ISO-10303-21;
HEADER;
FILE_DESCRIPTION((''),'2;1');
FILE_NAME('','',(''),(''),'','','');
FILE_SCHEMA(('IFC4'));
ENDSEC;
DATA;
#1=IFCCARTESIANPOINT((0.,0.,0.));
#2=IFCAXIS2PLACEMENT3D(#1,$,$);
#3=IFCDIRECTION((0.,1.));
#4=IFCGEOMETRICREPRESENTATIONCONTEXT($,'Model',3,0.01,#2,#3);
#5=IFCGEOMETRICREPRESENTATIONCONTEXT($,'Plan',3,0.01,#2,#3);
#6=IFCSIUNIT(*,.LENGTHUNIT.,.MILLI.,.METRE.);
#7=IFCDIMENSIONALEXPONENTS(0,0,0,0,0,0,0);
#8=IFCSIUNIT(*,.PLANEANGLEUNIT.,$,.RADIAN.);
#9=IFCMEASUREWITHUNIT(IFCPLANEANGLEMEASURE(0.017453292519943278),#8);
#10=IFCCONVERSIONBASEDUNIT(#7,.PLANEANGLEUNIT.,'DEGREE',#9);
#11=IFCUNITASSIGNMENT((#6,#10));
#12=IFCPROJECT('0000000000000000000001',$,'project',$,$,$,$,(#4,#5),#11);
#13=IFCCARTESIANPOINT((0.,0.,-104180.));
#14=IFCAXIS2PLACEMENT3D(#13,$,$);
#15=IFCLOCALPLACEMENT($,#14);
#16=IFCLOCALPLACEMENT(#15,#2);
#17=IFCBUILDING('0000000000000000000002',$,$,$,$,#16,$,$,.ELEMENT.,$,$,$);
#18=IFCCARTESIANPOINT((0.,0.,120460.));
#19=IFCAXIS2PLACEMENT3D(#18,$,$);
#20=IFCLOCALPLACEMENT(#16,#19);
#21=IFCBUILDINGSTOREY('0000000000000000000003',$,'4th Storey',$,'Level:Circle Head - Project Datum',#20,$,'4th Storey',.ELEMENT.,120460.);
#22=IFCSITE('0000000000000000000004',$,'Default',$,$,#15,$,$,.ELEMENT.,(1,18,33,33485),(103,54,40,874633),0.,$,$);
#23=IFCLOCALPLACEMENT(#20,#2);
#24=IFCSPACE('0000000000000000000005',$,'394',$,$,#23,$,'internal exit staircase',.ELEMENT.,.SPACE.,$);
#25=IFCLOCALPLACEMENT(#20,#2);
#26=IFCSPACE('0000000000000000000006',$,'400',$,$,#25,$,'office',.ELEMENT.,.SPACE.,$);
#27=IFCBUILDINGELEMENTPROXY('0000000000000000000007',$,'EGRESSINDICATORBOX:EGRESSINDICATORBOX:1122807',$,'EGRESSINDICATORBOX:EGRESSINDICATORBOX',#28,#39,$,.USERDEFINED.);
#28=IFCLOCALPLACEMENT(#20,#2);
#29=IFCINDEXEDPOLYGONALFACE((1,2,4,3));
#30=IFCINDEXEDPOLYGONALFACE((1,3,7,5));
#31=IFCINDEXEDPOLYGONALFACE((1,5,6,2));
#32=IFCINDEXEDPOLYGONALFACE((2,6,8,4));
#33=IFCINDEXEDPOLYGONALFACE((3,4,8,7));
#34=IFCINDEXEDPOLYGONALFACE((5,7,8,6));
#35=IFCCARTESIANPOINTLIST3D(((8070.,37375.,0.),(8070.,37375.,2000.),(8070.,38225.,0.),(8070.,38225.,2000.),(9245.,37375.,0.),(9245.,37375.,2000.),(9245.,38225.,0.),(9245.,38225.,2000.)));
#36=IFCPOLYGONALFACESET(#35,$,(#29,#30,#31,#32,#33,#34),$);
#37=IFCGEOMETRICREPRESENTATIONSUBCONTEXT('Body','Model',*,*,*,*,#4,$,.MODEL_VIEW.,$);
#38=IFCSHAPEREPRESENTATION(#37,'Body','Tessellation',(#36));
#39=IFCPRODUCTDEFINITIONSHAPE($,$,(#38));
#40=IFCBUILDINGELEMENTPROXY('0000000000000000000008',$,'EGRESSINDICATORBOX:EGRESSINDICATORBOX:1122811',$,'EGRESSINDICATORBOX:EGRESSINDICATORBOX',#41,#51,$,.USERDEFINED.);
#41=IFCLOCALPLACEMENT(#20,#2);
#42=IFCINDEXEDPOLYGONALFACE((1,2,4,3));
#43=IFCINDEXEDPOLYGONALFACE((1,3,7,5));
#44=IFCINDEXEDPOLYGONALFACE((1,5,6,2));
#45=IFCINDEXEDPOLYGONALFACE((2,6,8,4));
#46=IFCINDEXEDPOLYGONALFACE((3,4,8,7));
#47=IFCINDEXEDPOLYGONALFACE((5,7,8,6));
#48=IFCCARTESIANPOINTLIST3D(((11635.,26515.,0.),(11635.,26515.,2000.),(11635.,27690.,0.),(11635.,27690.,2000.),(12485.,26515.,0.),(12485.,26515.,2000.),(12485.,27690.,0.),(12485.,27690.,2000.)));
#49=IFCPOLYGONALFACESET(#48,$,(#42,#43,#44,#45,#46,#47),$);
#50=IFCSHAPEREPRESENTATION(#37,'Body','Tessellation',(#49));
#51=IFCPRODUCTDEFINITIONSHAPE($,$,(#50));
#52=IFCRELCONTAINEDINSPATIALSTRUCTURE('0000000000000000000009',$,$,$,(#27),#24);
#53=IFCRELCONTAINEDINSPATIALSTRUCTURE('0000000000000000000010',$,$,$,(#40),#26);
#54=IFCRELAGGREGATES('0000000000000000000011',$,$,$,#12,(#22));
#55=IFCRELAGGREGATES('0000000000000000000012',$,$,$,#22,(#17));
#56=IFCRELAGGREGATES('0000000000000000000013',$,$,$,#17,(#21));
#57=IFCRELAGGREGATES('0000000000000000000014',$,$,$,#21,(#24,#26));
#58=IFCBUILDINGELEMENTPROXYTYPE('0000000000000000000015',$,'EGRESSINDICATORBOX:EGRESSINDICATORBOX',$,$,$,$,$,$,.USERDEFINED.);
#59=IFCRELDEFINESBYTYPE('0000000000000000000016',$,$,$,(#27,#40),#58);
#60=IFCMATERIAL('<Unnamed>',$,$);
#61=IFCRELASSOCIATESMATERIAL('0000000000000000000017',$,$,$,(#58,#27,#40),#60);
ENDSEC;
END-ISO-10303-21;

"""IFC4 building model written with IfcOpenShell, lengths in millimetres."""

from ifc_helpers import new_model, entity, si_unit, converted_unit, direction, frame, origin, place, context, subcontext, project, spatial, indexed_curve, outline, extrude, source, transform, mapped, material, type_object, type_shapes, element, save


model = new_model("IFC4")

# Units and contexts
model_context = context("Model", 3, precision=0.01, world=origin(), true_north=direction((0.0, 1.0)))
plan_context = context("Plan", 3, precision=0.01, world=origin(), true_north=direction((0.0, 1.0)))
body_context = subcontext(model_context, "Body", "Model", "MODEL_VIEW")
ifc_project = project(units=[si_unit("LENGTHUNIT", "METRE", prefix="MILLI"), converted_unit("PLANEANGLEUNIT", "DEGREE", entity("IfcPlaneAngleMeasure", 0.017453292519943278), si_unit("PLANEANGLEUNIT", "RADIAN"), dimensions=[0, 0, 0, 0, 0, 0, 0])], contexts=[model_context, plan_context])

# Site, building, storey
site_placement = place(None, frame((0.0, 0.0, -104180.0)))
site = spatial("IfcSite", under=ifc_project, at=site_placement, Name="Default", CompositionType="ELEMENT", RefLatitude=(1, 18, 33, 33485), RefLongitude=(103, 54, 40, 874633), RefElevation=0.0)
building_placement = place(site_placement, origin())
building = spatial("IfcBuilding", under=site, at=building_placement, CompositionType="ELEMENT")
storey_placement = place(building_placement, frame((0.0, 0.0, 120460.0)))
storey = spatial("IfcBuildingStorey", under=building, at=storey_placement, Name="4th Storey", ObjectType="Level:Circle Head - Project Datum", LongName="4th Storey", CompositionType="ELEMENT", Elevation=120460.0)

# Shared definitions
ifc_material_1 = material(Name="<Unnamed>")

# Shared definitions
building_element_proxy_type_1 = type_object("IfcBuildingElementProxyType", Name="EGRESSINDICATORBOX:EGRESSINDICATORBOX", PredefinedType="USERDEFINED", material=ifc_material_1)
shared_shape_1 = source(origin(), body_context, "Body", "SweptSolid", [
    extrude(outline(indexed_curve([(-425.0, -587.5), (425.0, -587.5), (425.0, 587.5), (-425.0, 587.5), (-425.0, -587.5)], self_intersect=False)), frame((0.0, 0.0, 0.0), z_axis=(0.0, 0.0, 1.0), x_axis=(-1.0, 0.0, 0.0)), (0.0, 0.0, 1.0), 2000.0),
])
type_shapes(building_element_proxy_type_1, [shared_shape_1])

# Shared definitions
space_1_placement = place(storey_placement, origin())
space_1 = spatial("IfcSpace", under=storey, at=space_1_placement, Name="394", LongName="internal exit staircase", CompositionType="ELEMENT", PredefinedType="SPACE")

# Building element proxy
proxy_1_placement = place(space_1_placement, frame((8657.5, 37800.0, 0.0), z_axis=(0.0, 0.0, 1.0), x_axis=(0.0, 1.0, 0.0)))
element("IfcBuildingElementProxy", 1, at=proxy_1_placement, inside=space_1, type_object=building_element_proxy_type_1, material=ifc_material_1, Name="EGRESSINDICATORBOX:EGRESSINDICATORBOX:1122807", ObjectType="EGRESSINDICATORBOX:EGRESSINDICATORBOX", PredefinedType="USERDEFINED", context=body_context, shape_type="MappedRepresentation", body=[
    mapped(shared_shape_1, transform((0.0, 0.0, 0.0), scale=1.0)),
])

# Shared definitions
space_2_placement = place(storey_placement, origin())
space_2 = spatial("IfcSpace", under=storey, at=space_2_placement, Name="400", LongName="office", CompositionType="ELEMENT", PredefinedType="SPACE")

# Building element proxy
proxy_2_placement = place(space_2_placement, frame((12060.0, 27102.5, 0.0)))
element("IfcBuildingElementProxy", 2, at=proxy_2_placement, inside=space_2, type_object=building_element_proxy_type_1, material=ifc_material_1, Name="EGRESSINDICATORBOX:EGRESSINDICATORBOX:1122811", ObjectType="EGRESSINDICATORBOX:EGRESSINDICATORBOX", PredefinedType="USERDEFINED", context=body_context, shape_type="MappedRepresentation", body=[
    mapped(shared_shape_1, transform((0.0, 0.0, 0.0), scale=1.0)),
])

save(model, "model.ifc")
